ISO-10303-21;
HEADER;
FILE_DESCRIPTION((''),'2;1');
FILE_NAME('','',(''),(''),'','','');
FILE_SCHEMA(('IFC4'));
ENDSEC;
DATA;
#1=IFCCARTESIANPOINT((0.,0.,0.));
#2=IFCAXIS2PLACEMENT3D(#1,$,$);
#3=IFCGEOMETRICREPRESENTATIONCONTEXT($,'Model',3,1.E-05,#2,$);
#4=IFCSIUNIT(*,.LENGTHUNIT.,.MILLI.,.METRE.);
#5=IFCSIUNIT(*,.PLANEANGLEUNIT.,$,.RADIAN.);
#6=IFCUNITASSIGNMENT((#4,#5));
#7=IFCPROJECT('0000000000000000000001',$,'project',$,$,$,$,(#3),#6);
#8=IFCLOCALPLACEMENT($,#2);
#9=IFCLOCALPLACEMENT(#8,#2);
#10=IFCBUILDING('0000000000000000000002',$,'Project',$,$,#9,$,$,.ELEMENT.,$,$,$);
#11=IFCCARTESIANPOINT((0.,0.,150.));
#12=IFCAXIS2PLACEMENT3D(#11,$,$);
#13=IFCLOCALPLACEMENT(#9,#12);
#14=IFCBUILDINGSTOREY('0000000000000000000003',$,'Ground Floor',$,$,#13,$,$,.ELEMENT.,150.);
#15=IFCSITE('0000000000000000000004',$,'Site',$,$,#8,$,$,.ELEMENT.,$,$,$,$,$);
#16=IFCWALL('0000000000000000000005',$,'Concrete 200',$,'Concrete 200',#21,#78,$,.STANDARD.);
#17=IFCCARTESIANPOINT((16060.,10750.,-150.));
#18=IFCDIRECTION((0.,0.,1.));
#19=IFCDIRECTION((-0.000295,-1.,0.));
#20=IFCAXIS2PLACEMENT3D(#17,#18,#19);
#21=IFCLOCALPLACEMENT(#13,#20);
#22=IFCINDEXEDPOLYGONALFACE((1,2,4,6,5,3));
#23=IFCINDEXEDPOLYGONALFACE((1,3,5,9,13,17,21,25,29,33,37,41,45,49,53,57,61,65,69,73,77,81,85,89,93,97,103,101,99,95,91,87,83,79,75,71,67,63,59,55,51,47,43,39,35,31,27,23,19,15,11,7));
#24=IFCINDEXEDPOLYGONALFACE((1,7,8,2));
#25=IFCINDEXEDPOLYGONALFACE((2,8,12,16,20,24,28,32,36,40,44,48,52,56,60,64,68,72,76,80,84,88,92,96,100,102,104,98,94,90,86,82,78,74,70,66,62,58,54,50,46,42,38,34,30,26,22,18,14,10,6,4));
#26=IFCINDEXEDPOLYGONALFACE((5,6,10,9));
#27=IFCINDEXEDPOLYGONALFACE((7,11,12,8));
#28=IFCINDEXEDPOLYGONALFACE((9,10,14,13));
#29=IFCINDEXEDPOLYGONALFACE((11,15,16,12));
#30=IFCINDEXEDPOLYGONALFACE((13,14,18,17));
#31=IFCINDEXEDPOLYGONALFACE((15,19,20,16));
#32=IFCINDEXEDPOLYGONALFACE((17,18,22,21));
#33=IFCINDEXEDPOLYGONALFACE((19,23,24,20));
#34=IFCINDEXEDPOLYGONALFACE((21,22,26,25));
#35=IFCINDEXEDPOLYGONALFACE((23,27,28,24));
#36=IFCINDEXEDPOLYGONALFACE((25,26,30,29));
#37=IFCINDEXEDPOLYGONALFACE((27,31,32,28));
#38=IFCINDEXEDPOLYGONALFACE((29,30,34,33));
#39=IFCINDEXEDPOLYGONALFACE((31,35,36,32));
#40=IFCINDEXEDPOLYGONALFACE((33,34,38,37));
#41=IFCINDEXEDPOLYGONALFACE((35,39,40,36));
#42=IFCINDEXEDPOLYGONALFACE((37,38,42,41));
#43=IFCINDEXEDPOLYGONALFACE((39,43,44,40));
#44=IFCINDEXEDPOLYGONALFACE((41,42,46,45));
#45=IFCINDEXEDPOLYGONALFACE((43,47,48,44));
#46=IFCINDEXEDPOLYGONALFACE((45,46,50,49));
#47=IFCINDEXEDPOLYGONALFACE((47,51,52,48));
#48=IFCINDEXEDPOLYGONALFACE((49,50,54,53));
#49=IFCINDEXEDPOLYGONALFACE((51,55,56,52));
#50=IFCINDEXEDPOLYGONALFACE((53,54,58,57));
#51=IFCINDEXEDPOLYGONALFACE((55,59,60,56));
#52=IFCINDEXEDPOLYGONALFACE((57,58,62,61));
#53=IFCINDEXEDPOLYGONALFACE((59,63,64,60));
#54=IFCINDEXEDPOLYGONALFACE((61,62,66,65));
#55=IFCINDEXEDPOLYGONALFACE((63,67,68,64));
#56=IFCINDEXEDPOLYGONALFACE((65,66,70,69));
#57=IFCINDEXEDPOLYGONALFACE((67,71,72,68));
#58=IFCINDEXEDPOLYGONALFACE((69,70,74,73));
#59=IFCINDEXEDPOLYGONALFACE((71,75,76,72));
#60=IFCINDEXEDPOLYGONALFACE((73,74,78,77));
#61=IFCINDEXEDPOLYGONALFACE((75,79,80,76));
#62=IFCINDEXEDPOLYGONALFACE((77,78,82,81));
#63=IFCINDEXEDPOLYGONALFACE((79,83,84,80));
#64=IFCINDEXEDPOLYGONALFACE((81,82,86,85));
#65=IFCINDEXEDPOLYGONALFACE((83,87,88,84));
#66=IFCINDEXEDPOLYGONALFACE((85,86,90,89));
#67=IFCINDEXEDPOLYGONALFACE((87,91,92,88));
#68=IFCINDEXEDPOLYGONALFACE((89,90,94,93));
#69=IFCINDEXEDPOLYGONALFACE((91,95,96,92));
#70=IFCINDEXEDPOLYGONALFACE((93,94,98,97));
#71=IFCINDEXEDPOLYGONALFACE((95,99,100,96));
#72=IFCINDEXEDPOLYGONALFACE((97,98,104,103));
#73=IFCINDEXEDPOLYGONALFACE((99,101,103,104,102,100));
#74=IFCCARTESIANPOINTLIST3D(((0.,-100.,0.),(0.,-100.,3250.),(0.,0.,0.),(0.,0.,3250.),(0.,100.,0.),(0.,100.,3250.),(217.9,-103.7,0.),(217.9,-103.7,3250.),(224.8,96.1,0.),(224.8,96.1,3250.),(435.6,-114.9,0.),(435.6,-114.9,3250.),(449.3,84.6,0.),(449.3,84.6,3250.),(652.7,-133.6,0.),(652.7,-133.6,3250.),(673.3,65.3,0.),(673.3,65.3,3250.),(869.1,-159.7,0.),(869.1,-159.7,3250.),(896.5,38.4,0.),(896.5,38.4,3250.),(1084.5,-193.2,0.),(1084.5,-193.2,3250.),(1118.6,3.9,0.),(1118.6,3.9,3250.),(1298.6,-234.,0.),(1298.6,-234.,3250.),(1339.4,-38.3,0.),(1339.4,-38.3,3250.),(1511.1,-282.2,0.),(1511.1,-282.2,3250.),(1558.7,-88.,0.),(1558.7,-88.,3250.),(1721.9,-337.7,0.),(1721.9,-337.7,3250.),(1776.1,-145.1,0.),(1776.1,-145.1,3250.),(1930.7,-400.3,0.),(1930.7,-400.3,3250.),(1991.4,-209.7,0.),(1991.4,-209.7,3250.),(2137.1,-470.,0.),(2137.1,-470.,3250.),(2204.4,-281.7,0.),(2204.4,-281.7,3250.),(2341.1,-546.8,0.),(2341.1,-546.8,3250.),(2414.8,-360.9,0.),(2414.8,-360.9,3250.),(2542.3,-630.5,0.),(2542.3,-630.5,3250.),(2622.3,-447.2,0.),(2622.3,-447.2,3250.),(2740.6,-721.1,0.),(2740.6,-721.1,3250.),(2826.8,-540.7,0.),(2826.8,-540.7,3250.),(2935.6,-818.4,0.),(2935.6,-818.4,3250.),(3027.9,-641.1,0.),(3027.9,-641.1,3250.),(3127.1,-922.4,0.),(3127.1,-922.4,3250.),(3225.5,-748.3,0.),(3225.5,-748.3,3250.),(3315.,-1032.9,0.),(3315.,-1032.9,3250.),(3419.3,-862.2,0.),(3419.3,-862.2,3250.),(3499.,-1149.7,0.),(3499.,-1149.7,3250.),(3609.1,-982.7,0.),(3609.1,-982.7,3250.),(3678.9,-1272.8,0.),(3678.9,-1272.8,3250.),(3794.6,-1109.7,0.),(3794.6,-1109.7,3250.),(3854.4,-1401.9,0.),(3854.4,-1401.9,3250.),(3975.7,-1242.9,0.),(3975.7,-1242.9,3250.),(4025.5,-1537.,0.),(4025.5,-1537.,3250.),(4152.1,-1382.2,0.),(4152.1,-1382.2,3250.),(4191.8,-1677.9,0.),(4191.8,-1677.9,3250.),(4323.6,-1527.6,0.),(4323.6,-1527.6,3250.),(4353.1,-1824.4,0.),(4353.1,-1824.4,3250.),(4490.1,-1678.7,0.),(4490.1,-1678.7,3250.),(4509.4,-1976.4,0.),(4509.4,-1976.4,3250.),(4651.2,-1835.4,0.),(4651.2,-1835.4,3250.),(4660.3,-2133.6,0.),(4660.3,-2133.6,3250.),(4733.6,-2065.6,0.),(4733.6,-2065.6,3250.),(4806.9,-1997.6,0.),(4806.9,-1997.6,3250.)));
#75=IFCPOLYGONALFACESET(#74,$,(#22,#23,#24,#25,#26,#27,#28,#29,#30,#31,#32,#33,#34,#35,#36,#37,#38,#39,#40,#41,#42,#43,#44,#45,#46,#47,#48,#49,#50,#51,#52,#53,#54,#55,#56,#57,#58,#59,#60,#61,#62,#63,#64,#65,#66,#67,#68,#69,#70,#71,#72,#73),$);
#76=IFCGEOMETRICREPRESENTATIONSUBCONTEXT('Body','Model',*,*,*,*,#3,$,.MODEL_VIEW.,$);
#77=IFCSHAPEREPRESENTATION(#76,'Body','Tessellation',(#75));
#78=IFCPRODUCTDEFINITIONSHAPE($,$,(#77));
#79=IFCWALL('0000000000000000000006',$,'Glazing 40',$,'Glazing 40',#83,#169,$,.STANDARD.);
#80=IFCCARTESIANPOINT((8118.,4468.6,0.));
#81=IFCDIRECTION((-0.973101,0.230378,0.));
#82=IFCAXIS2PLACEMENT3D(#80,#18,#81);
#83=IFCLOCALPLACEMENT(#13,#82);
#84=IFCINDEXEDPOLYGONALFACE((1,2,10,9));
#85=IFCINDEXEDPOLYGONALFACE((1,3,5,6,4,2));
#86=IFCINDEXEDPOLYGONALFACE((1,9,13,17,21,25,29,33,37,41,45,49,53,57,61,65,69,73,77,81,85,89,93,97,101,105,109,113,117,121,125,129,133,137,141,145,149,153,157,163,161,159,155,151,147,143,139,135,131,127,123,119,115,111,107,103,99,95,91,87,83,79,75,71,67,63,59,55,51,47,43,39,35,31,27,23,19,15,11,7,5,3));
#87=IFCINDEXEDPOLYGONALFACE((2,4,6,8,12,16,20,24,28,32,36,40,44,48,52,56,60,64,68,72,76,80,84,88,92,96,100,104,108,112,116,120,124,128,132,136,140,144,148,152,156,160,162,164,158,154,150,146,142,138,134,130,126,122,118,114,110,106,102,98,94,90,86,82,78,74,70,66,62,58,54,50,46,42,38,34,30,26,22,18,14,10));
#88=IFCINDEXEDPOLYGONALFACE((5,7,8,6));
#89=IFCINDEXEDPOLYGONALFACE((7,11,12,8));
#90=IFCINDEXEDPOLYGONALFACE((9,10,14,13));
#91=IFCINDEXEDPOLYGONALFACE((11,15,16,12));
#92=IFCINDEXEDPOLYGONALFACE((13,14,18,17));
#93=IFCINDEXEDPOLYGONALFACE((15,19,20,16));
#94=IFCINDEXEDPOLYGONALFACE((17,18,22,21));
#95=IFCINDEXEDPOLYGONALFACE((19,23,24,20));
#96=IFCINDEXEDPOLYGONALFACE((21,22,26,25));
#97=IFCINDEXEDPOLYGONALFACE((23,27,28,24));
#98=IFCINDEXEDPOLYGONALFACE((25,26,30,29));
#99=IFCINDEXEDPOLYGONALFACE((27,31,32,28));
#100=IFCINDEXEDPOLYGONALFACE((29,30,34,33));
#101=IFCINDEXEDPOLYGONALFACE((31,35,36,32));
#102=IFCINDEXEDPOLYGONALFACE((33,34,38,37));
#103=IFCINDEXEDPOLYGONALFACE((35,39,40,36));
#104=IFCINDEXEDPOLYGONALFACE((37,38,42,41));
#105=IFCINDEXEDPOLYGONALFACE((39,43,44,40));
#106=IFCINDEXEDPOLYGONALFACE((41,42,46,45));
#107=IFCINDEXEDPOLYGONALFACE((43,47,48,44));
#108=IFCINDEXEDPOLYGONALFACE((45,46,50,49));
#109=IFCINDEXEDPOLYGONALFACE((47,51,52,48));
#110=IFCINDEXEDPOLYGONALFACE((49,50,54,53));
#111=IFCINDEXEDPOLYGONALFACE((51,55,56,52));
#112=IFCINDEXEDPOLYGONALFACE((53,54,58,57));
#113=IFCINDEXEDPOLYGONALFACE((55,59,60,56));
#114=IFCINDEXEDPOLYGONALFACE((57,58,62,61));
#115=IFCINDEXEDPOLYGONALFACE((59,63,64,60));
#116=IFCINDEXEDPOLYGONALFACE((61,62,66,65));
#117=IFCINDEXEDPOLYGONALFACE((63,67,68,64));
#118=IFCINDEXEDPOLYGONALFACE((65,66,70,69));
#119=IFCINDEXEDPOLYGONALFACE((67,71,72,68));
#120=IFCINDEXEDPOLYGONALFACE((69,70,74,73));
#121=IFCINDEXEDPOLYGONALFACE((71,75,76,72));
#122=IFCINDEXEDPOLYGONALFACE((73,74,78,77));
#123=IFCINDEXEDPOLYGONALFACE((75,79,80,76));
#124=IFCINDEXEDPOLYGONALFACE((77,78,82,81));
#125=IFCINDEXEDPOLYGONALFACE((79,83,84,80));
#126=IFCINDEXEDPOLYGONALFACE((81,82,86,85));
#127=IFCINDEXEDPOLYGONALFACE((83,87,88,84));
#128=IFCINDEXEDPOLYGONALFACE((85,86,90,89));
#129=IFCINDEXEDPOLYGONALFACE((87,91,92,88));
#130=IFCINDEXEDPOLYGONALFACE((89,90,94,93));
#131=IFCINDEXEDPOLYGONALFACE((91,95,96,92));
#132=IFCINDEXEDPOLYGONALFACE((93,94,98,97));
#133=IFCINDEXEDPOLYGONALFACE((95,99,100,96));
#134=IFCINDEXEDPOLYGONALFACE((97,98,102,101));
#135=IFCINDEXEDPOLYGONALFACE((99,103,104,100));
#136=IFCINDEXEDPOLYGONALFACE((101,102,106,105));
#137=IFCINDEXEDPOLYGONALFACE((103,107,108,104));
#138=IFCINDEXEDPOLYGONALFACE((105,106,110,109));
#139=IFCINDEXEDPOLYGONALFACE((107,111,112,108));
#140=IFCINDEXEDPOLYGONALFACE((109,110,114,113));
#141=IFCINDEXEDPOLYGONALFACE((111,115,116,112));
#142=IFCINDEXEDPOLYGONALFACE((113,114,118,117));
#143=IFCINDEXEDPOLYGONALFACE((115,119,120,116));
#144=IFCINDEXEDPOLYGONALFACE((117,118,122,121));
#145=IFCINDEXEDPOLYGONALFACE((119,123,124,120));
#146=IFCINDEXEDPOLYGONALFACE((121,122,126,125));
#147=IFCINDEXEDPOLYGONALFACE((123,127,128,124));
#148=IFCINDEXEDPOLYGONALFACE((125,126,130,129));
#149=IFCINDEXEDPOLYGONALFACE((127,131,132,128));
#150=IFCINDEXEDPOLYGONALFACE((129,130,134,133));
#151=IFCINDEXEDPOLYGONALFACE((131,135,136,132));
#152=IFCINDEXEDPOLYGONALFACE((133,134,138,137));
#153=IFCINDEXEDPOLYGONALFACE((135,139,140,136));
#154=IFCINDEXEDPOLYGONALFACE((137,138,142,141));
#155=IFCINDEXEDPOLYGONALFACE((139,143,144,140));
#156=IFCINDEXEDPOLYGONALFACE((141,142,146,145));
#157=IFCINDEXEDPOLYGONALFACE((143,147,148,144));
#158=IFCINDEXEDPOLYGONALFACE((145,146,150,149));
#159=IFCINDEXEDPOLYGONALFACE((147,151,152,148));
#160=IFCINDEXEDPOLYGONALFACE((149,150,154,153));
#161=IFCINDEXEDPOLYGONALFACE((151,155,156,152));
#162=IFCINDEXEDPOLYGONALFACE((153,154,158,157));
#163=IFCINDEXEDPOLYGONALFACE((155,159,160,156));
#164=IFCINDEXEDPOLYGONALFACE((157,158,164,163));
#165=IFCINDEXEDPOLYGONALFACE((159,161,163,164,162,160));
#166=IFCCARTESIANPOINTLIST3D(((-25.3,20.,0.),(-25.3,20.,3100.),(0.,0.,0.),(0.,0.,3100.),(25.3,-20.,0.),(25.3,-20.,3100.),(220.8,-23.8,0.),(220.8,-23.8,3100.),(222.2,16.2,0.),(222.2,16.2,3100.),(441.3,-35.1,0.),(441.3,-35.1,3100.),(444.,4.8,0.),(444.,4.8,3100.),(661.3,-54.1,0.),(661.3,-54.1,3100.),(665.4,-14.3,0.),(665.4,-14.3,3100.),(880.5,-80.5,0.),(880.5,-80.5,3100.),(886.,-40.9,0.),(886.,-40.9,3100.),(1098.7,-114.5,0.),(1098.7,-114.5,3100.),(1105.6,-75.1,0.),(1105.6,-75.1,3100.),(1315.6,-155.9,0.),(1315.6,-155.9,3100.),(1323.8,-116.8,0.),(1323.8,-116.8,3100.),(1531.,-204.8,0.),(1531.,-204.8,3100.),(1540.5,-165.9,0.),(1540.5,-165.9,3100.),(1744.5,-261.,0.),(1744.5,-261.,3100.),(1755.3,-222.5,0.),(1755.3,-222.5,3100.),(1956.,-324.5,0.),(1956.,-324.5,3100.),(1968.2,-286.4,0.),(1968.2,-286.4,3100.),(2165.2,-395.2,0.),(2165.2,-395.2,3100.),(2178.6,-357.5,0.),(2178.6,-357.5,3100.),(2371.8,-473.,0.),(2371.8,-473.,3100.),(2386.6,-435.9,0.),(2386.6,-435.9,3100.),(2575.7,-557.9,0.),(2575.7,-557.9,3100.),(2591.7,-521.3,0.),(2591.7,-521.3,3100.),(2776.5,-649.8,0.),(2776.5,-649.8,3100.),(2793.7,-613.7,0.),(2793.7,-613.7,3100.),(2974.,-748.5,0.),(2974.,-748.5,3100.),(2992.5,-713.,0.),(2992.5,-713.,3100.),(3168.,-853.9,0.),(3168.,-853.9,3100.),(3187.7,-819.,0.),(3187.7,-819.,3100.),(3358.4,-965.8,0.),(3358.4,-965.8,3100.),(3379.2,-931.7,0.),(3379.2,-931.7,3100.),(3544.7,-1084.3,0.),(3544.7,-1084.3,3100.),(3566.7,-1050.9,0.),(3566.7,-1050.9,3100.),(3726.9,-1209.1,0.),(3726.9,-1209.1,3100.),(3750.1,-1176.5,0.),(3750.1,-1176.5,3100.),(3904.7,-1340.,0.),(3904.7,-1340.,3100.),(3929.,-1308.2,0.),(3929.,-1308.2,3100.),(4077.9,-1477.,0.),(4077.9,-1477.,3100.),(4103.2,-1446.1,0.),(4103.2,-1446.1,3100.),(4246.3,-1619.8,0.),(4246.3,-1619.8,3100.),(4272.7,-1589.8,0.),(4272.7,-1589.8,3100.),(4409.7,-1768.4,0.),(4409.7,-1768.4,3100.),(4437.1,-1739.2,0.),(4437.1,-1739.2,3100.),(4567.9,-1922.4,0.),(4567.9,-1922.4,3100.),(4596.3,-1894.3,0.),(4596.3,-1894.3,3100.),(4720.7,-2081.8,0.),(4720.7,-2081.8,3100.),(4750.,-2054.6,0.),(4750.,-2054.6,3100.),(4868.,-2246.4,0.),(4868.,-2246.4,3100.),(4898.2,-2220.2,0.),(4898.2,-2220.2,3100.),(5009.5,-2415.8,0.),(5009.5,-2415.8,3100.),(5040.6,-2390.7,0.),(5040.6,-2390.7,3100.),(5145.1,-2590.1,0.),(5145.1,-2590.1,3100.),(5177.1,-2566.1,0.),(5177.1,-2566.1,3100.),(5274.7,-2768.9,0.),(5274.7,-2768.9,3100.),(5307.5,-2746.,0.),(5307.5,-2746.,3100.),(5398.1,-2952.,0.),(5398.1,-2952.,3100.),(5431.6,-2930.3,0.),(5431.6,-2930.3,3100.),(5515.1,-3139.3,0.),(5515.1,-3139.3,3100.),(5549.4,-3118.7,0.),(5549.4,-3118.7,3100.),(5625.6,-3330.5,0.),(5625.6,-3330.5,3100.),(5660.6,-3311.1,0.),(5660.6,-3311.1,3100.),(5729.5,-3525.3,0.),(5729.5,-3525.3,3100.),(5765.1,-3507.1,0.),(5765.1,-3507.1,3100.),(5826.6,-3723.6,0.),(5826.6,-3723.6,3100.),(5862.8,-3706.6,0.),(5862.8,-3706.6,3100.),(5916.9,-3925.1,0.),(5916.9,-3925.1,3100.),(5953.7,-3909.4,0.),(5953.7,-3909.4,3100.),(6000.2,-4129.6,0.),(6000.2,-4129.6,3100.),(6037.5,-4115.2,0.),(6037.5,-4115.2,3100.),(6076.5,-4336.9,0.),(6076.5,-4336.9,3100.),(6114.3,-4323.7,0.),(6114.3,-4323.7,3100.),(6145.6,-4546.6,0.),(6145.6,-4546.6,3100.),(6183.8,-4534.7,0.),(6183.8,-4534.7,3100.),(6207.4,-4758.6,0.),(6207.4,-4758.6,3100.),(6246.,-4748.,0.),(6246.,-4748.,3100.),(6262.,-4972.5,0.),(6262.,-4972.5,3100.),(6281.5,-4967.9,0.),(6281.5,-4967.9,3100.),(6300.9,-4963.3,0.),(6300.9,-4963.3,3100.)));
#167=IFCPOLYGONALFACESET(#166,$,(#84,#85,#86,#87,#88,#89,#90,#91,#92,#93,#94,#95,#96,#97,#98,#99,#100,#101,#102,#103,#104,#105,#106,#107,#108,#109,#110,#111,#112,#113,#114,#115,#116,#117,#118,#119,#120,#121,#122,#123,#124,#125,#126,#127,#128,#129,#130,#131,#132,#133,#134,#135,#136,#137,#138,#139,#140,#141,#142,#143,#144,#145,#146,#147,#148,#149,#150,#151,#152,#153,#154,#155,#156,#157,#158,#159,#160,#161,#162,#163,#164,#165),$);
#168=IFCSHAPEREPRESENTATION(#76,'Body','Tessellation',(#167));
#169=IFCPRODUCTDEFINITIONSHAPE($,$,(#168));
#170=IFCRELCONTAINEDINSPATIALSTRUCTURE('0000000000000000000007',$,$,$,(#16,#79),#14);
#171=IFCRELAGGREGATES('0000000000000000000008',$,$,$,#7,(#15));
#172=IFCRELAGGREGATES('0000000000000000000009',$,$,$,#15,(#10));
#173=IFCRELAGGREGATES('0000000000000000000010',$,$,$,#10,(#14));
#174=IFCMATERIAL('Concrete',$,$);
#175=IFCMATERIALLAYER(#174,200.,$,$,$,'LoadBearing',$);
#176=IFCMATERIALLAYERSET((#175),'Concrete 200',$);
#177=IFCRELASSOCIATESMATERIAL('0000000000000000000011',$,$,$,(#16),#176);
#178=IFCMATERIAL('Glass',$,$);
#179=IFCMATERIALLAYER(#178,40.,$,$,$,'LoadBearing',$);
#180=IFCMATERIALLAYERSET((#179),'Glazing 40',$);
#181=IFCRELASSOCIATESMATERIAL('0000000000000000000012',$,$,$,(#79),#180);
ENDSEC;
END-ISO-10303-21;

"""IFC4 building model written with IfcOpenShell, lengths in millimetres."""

from ifc_helpers import new_model, si_unit, frame, origin, place, context, subcontext, project, spatial, polyline, outline, extrude, material, layer, layer_set, layer_usage, element, save


model = new_model("IFC4")

# Units and contexts
model_context = context("Model", 3, precision=1e-05, world=origin())
body_context = subcontext(model_context, "Body", "Model", "MODEL_VIEW")
ifc_project = project(units=[si_unit("LENGTHUNIT", "METRE", prefix="MILLI"), si_unit("PLANEANGLEUNIT", "RADIAN")], contexts=[model_context])

# Site, building, storey
site_placement = place(None, origin())
site = spatial("IfcSite", under=ifc_project, at=site_placement, Name="Site", CompositionType="ELEMENT")
building_placement = place(site_placement, origin())
building = spatial("IfcBuilding", under=site, at=building_placement, Name="Project", CompositionType="ELEMENT")
storey_placement = place(building_placement, frame((0.0, 0.0, 150.0)))
storey = spatial("IfcBuildingStorey", under=building, at=storey_placement, Name="Ground Floor", CompositionType="ELEMENT", Elevation=150.0)

# Shared definitions
ifc_material_1 = material(Name="Concrete")

# Shared definitions
ifc_layer_1 = layer(ifc_material_1, 200.0, Category="LoadBearing")
ifc_layer_set_1 = layer_set([ifc_layer_1], Name="Concrete 200")
ifc_layer_usage_1 = layer_usage(ifc_layer_set_1, "AXIS2", "NEGATIVE", 100.0)

# Walls
wall_1_placement = place(storey_placement, frame((16060.0, 10750.0, -150.0), z_axis=(0.0, 0.0, 1.0), x_axis=(-0.000295, -1.0, 0.0)))
element("IfcWall", 1, at=wall_1_placement, inside=storey, material=ifc_layer_usage_1, Name="Concrete 200", ObjectType="Concrete 200", PredefinedType="STANDARD", context=body_context, shape_type="SweptSolid", body=[
    extrude(outline(polyline([(0.0, -100.0), (0.0, 0.0), (0.0, 100.0), (224.8, 96.1), (449.3, 84.6), (673.3, 65.3), (896.5, 38.4), (1118.6, 3.9), (1339.4, -38.3), (1558.7, -88.0), (1776.1, -145.1), (1991.4, -209.7), (2204.4, -281.7), (2414.8, -360.9), (2622.3, -447.2), (2826.8, -540.7), (3027.9, -641.1), (3225.5, -748.3), (3419.3, -862.2), (3609.1, -982.7), (3794.6, -1109.7), (3975.7, -1242.9), (4152.1, -1382.2), (4323.6, -1527.6), (4490.1, -1678.7), (4651.2, -1835.4), (4806.9, -1997.6), (4733.6, -2065.6), (4660.3, -2133.6), (4509.4, -1976.4), (4353.1, -1824.4), (4191.8, -1677.9), (4025.5, -1537.0), (3854.4, -1401.9), (3678.9, -1272.8), (3499.0, -1149.7), (3315.0, -1032.9), (3127.1, -922.4), (2935.6, -818.4), (2740.6, -721.1), (2542.3, -630.5), (2341.1, -546.8), (2137.1, -470.0), (1930.7, -400.3), (1721.9, -337.7), (1511.1, -282.2), (1298.6, -234.0), (1084.5, -193.2), (869.1, -159.7), (652.7, -133.6), (435.6, -114.9), (217.9, -103.7), (0.0, -100.0)])), origin(), (0.0, 0.0, 1.0), 3250.0),
])
ifc_material_2 = material(Name="Glass")
ifc_layer_2 = layer(ifc_material_2, 40.0, Category="LoadBearing")
ifc_layer_set_2 = layer_set([ifc_layer_2], Name="Glazing 40")
ifc_layer_usage_2 = layer_usage(ifc_layer_set_2, "AXIS2", "NEGATIVE", 20.0)
wall_2_placement = place(storey_placement, frame((8118.0, 4468.6, 0.0), z_axis=(0.0, 0.0, 1.0), x_axis=(-0.973101, 0.230378, 0.0)))
element("IfcWall", 2, at=wall_2_placement, inside=storey, material=ifc_layer_usage_2, Name="Glazing 40", ObjectType="Glazing 40", PredefinedType="STANDARD", context=body_context, shape_type="SweptSolid", body=[
    extrude(outline(polyline([(25.3, -20.0), (0.0, 0.0), (-25.3, 20.0), (222.2, 16.2), (444.0, 4.8), (665.4, -14.3), (886.0, -40.9), (1105.6, -75.1), (1323.8, -116.8), (1540.5, -165.9), (1755.3, -222.5), (1968.2, -286.4), (2178.6, -357.5), (2386.6, -435.9), (2591.7, -521.3), (2793.7, -613.7), (2992.5, -713.0), (3187.7, -819.0), (3379.2, -931.7), (3566.7, -1050.9), (3750.1, -1176.5), (3929.0, -1308.2), (4103.2, -1446.1), (4272.7, -1589.8), (4437.1, -1739.2), (4596.3, -1894.3), (4750.0, -2054.6), (4898.2, -2220.2), (5040.6, -2390.7), (5177.1, -2566.1), (5307.5, -2746.0), (5431.6, -2930.3), (5549.4, -3118.7), (5660.6, -3311.1), (5765.1, -3507.1), (5862.8, -3706.6), (5953.7, -3909.4), (6037.5, -4115.2), (6114.3, -4323.7), (6183.8, -4534.7), (6246.0, -4748.0), (6300.9, -4963.3), (6281.5, -4967.9), (6262.0, -4972.5), (6207.4, -4758.6), (6145.6, -4546.6), (6076.5, -4336.9), (6000.2, -4129.6), (5916.9, -3925.1), (5826.6, -3723.6), (5729.5, -3525.3), (5625.6, -3330.5), (5515.1, -3139.3), (5398.1, -2952.0), (5274.7, -2768.9), (5145.1, -2590.1), (5009.5, -2415.8), (4868.0, -2246.4), (4720.7, -2081.8), (4567.9, -1922.4), (4409.7, -1768.4), (4246.3, -1619.8), (4077.9, -1477.0), (3904.7, -1340.0), (3726.9, -1209.1), (3544.7, -1084.3), (3358.4, -965.8), (3168.0, -853.9), (2974.0, -748.5), (2776.5, -649.8), (2575.7, -557.9), (2371.8, -473.0), (2165.2, -395.2), (1956.0, -324.5), (1744.5, -261.0), (1531.0, -204.8), (1315.6, -155.9), (1098.7, -114.5), (880.5, -80.5), (661.3, -54.1), (441.3, -35.1), (220.8, -23.8), (25.3, -20.0)])), origin(), (0.0, 0.0, 1.0), 3100.0),
])

save(model, "model.ifc")
